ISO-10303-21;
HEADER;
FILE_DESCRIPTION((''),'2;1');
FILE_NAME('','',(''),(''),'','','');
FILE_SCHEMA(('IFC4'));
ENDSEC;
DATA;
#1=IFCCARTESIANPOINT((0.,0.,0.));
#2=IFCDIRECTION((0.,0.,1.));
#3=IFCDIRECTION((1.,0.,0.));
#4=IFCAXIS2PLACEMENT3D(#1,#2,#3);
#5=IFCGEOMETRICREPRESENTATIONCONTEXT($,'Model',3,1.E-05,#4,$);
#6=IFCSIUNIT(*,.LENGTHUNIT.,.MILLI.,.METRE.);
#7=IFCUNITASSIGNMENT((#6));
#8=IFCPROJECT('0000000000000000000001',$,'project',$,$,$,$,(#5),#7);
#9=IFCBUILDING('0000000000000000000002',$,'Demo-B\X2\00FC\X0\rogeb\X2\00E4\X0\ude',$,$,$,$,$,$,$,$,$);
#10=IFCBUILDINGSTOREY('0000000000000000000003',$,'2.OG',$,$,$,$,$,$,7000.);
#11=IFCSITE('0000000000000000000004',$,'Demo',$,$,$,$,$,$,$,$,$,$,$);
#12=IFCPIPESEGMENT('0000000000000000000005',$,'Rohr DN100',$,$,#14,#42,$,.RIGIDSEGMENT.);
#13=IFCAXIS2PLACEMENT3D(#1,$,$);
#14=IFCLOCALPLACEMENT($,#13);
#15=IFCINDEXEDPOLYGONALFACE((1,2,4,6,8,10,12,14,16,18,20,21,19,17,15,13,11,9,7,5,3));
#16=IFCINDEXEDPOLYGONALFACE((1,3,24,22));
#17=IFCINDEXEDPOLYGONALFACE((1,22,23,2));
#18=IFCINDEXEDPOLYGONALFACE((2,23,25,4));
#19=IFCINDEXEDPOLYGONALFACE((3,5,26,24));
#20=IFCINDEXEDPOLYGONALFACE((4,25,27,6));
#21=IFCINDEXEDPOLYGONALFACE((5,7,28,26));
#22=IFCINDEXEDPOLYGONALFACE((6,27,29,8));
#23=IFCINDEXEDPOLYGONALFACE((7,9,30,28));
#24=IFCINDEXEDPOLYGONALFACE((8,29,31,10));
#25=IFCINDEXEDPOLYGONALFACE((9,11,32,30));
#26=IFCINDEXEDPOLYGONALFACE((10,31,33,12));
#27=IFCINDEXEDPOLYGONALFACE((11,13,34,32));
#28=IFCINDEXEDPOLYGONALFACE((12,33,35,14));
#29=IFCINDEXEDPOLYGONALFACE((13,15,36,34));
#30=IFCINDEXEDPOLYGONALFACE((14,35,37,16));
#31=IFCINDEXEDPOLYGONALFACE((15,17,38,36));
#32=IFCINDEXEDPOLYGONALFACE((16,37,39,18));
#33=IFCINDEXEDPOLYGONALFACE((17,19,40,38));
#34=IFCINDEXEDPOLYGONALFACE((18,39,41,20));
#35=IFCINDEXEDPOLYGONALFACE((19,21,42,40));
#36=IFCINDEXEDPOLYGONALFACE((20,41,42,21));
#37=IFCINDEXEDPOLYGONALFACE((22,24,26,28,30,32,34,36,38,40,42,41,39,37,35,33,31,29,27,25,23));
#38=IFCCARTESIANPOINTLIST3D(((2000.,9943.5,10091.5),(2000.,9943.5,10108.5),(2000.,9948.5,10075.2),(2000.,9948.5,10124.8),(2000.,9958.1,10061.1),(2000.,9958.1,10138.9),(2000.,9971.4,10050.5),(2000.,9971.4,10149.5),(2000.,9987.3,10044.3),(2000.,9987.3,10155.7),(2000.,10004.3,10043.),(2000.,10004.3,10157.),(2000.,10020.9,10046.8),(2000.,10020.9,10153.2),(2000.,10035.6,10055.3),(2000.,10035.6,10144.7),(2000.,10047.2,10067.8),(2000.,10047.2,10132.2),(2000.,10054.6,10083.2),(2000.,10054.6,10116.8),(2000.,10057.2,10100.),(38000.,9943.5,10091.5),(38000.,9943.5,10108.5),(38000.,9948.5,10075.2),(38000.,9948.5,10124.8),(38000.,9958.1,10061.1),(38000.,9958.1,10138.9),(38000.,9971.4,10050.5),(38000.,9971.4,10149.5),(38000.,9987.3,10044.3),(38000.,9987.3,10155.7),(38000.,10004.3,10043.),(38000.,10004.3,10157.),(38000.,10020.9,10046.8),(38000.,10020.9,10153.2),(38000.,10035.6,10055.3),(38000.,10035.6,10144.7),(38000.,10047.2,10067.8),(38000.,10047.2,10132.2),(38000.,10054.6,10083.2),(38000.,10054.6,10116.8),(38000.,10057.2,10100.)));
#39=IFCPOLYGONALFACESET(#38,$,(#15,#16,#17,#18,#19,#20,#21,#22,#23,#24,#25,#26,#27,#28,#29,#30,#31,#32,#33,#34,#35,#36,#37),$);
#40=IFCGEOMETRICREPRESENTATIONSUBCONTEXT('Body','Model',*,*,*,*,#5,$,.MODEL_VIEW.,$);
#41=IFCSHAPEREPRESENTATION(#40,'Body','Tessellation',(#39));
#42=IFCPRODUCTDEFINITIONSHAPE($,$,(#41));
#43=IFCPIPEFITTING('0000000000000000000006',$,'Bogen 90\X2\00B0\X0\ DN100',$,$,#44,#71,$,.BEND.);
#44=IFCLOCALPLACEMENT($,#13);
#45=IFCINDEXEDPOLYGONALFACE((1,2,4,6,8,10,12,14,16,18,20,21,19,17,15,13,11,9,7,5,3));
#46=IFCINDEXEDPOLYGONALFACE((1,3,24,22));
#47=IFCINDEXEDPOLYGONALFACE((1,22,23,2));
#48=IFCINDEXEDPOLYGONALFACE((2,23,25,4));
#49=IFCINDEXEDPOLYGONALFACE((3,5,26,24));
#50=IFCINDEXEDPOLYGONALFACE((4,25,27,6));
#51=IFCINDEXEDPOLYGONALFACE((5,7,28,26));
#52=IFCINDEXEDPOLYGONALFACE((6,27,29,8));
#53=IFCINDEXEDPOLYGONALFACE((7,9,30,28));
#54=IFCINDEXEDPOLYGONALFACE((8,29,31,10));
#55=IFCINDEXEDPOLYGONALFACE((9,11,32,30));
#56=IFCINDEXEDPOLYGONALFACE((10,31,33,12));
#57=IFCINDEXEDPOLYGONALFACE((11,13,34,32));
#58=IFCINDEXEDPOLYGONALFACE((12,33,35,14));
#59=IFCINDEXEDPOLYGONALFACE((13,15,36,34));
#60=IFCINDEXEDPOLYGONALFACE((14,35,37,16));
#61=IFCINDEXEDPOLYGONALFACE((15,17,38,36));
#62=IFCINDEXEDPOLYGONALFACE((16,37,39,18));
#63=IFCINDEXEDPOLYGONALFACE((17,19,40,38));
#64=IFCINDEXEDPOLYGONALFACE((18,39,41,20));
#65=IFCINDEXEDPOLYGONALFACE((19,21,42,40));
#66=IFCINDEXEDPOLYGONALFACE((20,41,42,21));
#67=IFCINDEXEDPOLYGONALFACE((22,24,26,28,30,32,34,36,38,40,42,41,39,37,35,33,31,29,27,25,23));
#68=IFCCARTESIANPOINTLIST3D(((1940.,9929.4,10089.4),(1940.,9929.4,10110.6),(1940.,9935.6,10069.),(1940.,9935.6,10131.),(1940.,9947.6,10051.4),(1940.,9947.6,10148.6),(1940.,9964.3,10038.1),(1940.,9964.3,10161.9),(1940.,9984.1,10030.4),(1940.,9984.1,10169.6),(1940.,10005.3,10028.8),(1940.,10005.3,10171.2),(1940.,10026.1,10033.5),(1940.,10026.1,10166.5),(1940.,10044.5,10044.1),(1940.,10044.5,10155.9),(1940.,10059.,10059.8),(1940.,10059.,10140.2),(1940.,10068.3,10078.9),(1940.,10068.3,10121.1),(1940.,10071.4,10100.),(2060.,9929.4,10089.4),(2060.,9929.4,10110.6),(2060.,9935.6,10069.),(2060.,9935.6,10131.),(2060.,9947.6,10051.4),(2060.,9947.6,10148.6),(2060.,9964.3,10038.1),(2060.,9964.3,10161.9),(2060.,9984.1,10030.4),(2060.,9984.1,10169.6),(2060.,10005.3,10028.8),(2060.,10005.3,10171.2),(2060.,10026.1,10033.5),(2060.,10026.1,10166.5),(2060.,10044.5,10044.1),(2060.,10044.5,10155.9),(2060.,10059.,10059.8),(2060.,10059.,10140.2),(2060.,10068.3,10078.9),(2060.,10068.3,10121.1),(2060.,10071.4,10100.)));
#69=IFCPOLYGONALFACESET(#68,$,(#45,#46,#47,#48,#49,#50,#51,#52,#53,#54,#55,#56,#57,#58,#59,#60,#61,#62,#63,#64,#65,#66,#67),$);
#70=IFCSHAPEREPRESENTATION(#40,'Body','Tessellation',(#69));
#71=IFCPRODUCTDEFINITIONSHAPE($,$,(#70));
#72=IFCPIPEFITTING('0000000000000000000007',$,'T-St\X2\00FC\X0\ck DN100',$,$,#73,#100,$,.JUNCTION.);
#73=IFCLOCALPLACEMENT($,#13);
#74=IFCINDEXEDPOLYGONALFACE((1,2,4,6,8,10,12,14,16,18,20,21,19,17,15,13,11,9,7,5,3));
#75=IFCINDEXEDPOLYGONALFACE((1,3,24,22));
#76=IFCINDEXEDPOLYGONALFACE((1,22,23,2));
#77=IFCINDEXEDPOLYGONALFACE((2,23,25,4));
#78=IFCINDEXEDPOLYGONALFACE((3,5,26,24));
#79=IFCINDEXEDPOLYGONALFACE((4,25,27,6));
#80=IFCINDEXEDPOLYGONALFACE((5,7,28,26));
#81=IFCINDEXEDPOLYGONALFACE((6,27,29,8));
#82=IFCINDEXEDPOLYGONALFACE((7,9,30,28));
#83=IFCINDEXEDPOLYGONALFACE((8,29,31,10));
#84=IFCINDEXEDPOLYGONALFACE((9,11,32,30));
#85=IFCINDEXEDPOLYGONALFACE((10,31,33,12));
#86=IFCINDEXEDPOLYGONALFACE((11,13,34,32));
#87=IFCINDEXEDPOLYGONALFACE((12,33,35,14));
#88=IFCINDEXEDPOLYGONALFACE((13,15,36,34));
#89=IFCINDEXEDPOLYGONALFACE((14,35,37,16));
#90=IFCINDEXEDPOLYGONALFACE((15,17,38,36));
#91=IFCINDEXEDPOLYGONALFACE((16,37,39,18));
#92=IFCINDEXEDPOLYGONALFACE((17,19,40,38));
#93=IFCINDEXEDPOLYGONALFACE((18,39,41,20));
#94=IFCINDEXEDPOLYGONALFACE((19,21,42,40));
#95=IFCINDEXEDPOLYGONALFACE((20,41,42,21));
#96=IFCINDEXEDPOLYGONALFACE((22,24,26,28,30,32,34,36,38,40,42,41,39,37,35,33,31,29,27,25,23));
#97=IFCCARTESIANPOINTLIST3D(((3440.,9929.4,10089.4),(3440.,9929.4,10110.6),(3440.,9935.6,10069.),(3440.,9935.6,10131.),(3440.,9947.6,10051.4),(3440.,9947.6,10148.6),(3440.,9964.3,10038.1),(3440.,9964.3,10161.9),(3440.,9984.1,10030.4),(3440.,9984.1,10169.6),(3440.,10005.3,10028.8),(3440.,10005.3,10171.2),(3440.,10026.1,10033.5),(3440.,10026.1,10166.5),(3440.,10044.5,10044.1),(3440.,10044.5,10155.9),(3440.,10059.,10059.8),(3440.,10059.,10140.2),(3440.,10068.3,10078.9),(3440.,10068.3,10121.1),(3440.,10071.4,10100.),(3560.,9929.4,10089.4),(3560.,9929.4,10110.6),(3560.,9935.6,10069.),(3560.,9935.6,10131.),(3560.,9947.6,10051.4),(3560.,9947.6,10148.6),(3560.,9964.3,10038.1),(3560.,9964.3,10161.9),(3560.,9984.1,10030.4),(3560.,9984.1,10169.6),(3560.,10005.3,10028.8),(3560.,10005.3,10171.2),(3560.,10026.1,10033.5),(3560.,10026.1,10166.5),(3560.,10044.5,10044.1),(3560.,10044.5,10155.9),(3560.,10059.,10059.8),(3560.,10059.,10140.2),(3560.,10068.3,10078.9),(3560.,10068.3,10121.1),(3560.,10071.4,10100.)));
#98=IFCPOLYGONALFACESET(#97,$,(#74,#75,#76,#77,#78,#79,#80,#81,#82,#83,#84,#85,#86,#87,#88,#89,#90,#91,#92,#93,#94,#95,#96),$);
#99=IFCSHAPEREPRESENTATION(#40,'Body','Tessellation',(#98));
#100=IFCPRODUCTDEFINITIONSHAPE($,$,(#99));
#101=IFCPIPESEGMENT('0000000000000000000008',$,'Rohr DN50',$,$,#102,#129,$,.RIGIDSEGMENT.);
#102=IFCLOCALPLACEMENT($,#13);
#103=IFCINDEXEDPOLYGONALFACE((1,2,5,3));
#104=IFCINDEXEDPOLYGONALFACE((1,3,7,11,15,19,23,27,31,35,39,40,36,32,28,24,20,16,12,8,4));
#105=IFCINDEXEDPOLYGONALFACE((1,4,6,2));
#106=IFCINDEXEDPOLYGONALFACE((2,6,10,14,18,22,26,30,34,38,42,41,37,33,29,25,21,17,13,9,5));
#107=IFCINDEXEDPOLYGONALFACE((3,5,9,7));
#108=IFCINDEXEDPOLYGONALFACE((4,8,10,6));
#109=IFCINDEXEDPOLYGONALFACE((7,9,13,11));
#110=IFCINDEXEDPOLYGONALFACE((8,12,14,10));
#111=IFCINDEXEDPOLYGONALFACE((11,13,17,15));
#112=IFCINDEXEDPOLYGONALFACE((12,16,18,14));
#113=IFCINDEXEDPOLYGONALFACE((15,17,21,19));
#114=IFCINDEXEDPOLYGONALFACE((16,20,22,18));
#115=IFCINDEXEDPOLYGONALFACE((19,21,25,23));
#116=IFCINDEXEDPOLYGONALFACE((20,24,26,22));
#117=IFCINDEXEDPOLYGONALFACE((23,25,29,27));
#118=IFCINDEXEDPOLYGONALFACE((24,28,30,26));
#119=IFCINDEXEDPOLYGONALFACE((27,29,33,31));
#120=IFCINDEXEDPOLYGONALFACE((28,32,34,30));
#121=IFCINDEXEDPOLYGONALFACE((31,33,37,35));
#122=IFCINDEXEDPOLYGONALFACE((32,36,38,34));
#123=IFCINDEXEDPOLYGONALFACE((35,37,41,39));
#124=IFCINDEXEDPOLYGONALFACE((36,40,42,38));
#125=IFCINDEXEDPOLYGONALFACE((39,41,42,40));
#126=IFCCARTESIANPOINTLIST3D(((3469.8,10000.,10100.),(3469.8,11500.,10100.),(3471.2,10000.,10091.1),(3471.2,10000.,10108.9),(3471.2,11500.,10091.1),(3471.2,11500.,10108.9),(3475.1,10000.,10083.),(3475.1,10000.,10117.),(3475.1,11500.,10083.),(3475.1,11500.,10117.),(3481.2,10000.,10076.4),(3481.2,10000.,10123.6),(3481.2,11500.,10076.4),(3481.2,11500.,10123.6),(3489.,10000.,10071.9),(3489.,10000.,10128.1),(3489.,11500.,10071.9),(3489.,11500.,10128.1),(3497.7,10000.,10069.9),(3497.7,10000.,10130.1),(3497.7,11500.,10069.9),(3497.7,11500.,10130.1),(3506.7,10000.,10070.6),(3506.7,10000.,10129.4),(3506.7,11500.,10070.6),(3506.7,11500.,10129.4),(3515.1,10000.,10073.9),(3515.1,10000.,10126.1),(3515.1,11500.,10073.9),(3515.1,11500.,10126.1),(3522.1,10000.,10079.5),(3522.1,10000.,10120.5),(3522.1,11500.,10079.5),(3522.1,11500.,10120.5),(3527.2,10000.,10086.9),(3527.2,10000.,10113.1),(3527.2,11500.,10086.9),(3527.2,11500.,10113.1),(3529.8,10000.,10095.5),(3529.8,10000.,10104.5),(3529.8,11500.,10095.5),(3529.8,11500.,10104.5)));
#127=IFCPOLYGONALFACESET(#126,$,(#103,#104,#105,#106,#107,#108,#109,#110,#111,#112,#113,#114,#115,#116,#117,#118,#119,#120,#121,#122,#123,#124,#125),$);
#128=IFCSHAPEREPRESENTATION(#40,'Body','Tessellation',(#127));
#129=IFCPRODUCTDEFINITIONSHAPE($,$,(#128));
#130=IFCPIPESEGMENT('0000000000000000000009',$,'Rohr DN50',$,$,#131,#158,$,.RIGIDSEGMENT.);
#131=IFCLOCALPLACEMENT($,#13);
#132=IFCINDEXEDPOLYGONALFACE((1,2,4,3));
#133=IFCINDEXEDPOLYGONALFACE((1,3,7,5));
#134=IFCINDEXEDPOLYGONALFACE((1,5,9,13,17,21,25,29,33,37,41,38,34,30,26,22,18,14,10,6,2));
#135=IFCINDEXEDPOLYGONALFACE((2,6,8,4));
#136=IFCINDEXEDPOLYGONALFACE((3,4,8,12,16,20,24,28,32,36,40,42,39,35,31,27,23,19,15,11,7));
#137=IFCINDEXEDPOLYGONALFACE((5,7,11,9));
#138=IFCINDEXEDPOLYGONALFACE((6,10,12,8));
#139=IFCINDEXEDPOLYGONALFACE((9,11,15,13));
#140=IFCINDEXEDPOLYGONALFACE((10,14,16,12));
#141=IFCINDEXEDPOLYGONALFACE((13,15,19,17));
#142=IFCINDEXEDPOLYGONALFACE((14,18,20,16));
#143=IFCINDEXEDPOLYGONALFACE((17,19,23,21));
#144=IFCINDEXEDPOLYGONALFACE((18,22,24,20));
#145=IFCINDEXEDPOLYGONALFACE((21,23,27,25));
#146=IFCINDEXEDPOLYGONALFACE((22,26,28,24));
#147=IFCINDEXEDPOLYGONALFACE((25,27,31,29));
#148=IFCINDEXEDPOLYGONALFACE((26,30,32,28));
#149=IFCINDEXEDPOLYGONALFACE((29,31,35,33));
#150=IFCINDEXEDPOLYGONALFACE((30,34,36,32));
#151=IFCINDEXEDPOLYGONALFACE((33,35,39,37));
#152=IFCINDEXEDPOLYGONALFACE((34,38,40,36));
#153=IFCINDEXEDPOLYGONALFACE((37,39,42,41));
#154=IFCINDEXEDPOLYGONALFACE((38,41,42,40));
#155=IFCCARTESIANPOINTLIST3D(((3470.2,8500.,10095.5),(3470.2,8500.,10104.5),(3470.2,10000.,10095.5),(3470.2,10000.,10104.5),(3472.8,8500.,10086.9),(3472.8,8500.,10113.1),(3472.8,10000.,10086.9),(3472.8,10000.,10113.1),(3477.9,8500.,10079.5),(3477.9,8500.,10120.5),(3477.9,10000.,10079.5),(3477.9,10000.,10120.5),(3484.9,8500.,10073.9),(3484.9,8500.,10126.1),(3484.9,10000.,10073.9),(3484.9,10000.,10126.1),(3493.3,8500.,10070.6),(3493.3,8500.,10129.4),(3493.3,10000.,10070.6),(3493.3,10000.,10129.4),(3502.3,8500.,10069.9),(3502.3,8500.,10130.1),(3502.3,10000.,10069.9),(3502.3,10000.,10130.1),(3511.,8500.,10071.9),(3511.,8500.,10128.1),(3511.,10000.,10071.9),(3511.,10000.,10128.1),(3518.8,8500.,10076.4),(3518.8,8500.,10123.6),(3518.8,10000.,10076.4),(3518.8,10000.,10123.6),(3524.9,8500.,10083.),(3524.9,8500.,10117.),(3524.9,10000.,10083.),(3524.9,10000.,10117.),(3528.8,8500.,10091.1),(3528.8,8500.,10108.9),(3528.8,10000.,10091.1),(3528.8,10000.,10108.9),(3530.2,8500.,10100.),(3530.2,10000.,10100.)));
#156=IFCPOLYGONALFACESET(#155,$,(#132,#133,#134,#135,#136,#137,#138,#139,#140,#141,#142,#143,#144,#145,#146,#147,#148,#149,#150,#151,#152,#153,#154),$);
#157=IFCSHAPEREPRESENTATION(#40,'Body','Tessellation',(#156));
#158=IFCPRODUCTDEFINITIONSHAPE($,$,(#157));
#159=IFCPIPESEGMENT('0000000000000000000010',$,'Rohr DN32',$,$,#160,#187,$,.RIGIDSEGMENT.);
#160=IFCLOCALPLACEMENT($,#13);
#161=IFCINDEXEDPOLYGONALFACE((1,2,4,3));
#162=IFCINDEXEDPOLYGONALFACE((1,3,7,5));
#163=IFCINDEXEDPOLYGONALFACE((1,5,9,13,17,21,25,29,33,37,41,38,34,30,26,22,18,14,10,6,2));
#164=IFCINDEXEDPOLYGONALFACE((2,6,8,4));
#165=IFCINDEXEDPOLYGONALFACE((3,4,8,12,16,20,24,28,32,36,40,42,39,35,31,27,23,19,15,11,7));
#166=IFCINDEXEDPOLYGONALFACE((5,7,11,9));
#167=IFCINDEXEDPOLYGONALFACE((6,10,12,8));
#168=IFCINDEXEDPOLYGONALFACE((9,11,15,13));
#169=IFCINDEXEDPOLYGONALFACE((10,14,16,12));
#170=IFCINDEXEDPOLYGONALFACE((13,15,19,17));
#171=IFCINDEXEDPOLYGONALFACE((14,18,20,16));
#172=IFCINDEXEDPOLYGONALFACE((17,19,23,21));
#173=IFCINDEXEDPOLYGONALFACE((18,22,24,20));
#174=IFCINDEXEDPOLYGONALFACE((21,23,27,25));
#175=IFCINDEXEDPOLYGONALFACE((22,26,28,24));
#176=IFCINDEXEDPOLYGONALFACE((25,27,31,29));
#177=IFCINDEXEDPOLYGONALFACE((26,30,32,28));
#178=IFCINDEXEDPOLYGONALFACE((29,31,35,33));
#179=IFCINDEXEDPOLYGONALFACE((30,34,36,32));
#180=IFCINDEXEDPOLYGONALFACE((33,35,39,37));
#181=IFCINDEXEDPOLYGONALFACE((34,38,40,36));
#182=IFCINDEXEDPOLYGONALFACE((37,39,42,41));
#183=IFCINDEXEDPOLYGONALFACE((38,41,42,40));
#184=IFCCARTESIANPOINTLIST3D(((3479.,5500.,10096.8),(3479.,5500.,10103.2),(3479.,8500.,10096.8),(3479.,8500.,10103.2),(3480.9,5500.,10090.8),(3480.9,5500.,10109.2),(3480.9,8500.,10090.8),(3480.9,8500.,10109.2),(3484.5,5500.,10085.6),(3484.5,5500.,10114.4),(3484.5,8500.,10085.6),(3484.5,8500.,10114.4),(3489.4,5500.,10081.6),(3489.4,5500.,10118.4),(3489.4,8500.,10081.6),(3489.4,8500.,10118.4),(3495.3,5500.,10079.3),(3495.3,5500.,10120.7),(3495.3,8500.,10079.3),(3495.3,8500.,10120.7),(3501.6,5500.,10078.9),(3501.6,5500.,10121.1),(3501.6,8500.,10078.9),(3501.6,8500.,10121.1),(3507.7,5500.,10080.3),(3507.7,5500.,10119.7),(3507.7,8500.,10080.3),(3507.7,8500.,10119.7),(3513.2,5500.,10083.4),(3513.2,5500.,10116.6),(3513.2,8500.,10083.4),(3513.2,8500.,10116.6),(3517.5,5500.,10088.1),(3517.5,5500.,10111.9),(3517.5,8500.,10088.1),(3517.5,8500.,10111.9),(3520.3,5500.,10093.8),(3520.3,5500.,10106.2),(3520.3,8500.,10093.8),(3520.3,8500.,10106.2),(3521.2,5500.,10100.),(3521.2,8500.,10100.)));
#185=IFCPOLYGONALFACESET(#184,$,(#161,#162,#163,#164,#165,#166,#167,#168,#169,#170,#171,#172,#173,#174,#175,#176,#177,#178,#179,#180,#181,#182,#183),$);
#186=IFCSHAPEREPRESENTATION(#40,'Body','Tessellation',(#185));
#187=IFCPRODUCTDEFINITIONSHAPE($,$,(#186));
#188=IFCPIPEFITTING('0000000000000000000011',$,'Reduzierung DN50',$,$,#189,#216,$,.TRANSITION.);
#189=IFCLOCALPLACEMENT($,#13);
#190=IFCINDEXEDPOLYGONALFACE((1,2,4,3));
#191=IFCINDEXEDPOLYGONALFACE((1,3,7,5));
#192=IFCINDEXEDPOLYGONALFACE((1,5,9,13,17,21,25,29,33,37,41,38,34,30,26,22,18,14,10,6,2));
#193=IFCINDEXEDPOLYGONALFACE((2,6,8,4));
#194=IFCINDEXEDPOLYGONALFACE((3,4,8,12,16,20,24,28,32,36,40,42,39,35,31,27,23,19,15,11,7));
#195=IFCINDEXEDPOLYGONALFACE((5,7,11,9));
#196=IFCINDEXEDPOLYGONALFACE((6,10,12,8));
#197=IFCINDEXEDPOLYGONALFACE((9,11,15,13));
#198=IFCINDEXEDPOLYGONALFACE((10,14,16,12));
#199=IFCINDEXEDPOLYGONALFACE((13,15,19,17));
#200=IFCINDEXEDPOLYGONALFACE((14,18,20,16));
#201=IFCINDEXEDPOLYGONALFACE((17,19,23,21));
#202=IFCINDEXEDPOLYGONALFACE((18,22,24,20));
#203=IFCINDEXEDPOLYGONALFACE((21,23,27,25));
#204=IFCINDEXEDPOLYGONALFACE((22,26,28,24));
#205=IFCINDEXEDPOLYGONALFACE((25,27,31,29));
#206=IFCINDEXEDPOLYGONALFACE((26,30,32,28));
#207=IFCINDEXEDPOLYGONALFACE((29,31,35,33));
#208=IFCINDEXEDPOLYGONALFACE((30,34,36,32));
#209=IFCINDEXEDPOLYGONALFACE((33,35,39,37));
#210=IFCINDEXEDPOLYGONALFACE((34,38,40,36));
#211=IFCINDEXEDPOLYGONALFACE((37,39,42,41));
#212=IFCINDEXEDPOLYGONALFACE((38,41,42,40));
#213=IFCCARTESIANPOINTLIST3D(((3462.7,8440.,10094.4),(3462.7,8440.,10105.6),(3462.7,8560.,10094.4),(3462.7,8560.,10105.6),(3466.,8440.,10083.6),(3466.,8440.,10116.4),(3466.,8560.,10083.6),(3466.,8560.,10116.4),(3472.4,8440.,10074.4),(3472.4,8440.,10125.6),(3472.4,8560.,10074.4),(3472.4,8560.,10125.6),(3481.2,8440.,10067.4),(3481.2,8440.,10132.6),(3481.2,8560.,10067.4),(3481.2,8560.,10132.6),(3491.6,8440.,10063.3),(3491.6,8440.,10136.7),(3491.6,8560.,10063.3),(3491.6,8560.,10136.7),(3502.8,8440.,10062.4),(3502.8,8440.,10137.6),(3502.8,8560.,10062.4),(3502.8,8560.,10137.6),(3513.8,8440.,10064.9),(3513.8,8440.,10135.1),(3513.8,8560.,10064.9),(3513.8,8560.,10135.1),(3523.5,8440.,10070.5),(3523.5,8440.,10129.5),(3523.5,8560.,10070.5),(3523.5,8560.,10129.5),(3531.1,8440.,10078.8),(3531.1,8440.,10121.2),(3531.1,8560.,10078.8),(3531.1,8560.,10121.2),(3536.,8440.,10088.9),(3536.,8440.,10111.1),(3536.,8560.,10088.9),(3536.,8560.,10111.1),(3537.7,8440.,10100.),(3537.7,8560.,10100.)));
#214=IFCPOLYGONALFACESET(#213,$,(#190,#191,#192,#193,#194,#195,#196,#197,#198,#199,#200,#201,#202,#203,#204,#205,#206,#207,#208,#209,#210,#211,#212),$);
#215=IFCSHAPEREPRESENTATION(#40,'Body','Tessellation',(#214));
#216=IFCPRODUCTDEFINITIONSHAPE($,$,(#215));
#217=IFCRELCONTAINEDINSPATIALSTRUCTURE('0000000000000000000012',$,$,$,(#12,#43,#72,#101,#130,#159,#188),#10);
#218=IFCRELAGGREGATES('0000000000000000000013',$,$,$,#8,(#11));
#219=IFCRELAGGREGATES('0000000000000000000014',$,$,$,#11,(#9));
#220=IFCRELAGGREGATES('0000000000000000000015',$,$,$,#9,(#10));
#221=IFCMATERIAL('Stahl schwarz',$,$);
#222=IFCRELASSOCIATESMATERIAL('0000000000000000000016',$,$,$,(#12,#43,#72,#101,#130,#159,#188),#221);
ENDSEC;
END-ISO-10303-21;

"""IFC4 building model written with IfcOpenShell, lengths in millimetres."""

from ifc_helpers import new_model, si_unit, frame, origin_with_axes, place, context, subcontext, project, spatial, circle, extrude, material, element, save


model = new_model("IFC4")

# Units and contexts
model_context = context("Model", 3, precision=1e-05, world=origin_with_axes())
body_context = subcontext(model_context, "Body", "Model", "MODEL_VIEW")
ifc_project = project(units=[si_unit("LENGTHUNIT", "METRE", prefix="MILLI")], contexts=[model_context])

# Site, building, storey
site = spatial("IfcSite", under=ifc_project, Name="Demo")
building = spatial("IfcBuilding", under=site, Name="Demo-Bürogebäude")
storey = spatial("IfcBuildingStorey", under=building, Name="2.OG", Elevation=7000.0)

# Pipe segment
ifc_material_1 = material(Name="Stahl schwarz")
pipe_segment_1_placement = place(None, frame((2000.0, 10000.0, 10100.0), z_axis=(1.0, 0.0, 0.0), x_axis=(0.0, 1.0, 0.0)))
element("IfcPipeSegment", 1, at=pipe_segment_1_placement, inside=storey, material=ifc_material_1, Name="Rohr DN100", PredefinedType="RIGIDSEGMENT", context=body_context, shape_type="SweptSolid", body=[
    extrude(circle(Radius=57.1), origin_with_axes(), (0.0, 0.0, 1.0), 36000.0),
])

# Pipe fittings
pipe_fitting_1_placement = place(None, frame((1940.0, 10000.0, 10100.0), z_axis=(1.0, 0.0, 0.0), x_axis=(0.0, 1.0, 0.0)))
element("IfcPipeFitting", 2, at=pipe_fitting_1_placement, inside=storey, material=ifc_material_1, Name="Bogen 90° DN100", PredefinedType="BEND", context=body_context, shape_type="SweptSolid", body=[
    extrude(circle(Radius=71.4), origin_with_axes(), (0.0, 0.0, 1.0), 120.0),
])
pipe_fitting_2_placement = place(None, frame((3440.0, 10000.0, 10100.0), z_axis=(1.0, 0.0, 0.0), x_axis=(0.0, 1.0, 0.0)))
element("IfcPipeFitting", 3, at=pipe_fitting_2_placement, inside=storey, material=ifc_material_1, Name="T-Stück DN100", PredefinedType="JUNCTION", context=body_context, shape_type="SweptSolid", body=[
    extrude(circle(Radius=71.4), origin_with_axes(), (0.0, 0.0, 1.0), 120.0),
])

# Pipe segments
for number, where, z_axis, x_axis, name in (
    (4, (3500.0, 10000.0, 10100.0), (0.0, 1.0, 0.0), (-1.0, 0.0, 0.0), "Rohr DN50"),
    (5, (3500.0, 10000.0, 10100.0), (0.0, -1.0, 0.0), (1.0, 0.0, 0.0), "Rohr DN50"),
):
    element("IfcPipeSegment", number, at=place(None, frame(where, z_axis=z_axis, x_axis=x_axis)), inside=storey, material=ifc_material_1, Name=name, PredefinedType="RIGIDSEGMENT", context=body_context, shape_type="SweptSolid", body=[
        extrude(circle(Radius=30.1), origin_with_axes(), (0.0, 0.0, 1.0), 1500.0),
    ])
pipe_segment_2_placement = place(None, frame((3500.0, 8500.0, 10100.0), z_axis=(0.0, -1.0, 0.0), x_axis=(1.0, 0.0, 0.0)))
element("IfcPipeSegment", 6, at=pipe_segment_2_placement, inside=storey, material=ifc_material_1, Name="Rohr DN32", PredefinedType="RIGIDSEGMENT", context=body_context, shape_type="SweptSolid", body=[
    extrude(circle(Radius=21.2), origin_with_axes(), (0.0, 0.0, 1.0), 3000.0),
])

# Pipe fitting
pipe_fitting_3_placement = place(None, frame((3500.0, 8560.0, 10100.0), z_axis=(0.0, -1.0, 0.0), x_axis=(1.0, 0.0, 0.0)))
element("IfcPipeFitting", 7, at=pipe_fitting_3_placement, inside=storey, material=ifc_material_1, Name="Reduzierung DN50", PredefinedType="TRANSITION", context=body_context, shape_type="SweptSolid", body=[
    extrude(circle(Radius=37.7), origin_with_axes(), (0.0, 0.0, 1.0), 120.0),
])

save(model, "model.ifc")
